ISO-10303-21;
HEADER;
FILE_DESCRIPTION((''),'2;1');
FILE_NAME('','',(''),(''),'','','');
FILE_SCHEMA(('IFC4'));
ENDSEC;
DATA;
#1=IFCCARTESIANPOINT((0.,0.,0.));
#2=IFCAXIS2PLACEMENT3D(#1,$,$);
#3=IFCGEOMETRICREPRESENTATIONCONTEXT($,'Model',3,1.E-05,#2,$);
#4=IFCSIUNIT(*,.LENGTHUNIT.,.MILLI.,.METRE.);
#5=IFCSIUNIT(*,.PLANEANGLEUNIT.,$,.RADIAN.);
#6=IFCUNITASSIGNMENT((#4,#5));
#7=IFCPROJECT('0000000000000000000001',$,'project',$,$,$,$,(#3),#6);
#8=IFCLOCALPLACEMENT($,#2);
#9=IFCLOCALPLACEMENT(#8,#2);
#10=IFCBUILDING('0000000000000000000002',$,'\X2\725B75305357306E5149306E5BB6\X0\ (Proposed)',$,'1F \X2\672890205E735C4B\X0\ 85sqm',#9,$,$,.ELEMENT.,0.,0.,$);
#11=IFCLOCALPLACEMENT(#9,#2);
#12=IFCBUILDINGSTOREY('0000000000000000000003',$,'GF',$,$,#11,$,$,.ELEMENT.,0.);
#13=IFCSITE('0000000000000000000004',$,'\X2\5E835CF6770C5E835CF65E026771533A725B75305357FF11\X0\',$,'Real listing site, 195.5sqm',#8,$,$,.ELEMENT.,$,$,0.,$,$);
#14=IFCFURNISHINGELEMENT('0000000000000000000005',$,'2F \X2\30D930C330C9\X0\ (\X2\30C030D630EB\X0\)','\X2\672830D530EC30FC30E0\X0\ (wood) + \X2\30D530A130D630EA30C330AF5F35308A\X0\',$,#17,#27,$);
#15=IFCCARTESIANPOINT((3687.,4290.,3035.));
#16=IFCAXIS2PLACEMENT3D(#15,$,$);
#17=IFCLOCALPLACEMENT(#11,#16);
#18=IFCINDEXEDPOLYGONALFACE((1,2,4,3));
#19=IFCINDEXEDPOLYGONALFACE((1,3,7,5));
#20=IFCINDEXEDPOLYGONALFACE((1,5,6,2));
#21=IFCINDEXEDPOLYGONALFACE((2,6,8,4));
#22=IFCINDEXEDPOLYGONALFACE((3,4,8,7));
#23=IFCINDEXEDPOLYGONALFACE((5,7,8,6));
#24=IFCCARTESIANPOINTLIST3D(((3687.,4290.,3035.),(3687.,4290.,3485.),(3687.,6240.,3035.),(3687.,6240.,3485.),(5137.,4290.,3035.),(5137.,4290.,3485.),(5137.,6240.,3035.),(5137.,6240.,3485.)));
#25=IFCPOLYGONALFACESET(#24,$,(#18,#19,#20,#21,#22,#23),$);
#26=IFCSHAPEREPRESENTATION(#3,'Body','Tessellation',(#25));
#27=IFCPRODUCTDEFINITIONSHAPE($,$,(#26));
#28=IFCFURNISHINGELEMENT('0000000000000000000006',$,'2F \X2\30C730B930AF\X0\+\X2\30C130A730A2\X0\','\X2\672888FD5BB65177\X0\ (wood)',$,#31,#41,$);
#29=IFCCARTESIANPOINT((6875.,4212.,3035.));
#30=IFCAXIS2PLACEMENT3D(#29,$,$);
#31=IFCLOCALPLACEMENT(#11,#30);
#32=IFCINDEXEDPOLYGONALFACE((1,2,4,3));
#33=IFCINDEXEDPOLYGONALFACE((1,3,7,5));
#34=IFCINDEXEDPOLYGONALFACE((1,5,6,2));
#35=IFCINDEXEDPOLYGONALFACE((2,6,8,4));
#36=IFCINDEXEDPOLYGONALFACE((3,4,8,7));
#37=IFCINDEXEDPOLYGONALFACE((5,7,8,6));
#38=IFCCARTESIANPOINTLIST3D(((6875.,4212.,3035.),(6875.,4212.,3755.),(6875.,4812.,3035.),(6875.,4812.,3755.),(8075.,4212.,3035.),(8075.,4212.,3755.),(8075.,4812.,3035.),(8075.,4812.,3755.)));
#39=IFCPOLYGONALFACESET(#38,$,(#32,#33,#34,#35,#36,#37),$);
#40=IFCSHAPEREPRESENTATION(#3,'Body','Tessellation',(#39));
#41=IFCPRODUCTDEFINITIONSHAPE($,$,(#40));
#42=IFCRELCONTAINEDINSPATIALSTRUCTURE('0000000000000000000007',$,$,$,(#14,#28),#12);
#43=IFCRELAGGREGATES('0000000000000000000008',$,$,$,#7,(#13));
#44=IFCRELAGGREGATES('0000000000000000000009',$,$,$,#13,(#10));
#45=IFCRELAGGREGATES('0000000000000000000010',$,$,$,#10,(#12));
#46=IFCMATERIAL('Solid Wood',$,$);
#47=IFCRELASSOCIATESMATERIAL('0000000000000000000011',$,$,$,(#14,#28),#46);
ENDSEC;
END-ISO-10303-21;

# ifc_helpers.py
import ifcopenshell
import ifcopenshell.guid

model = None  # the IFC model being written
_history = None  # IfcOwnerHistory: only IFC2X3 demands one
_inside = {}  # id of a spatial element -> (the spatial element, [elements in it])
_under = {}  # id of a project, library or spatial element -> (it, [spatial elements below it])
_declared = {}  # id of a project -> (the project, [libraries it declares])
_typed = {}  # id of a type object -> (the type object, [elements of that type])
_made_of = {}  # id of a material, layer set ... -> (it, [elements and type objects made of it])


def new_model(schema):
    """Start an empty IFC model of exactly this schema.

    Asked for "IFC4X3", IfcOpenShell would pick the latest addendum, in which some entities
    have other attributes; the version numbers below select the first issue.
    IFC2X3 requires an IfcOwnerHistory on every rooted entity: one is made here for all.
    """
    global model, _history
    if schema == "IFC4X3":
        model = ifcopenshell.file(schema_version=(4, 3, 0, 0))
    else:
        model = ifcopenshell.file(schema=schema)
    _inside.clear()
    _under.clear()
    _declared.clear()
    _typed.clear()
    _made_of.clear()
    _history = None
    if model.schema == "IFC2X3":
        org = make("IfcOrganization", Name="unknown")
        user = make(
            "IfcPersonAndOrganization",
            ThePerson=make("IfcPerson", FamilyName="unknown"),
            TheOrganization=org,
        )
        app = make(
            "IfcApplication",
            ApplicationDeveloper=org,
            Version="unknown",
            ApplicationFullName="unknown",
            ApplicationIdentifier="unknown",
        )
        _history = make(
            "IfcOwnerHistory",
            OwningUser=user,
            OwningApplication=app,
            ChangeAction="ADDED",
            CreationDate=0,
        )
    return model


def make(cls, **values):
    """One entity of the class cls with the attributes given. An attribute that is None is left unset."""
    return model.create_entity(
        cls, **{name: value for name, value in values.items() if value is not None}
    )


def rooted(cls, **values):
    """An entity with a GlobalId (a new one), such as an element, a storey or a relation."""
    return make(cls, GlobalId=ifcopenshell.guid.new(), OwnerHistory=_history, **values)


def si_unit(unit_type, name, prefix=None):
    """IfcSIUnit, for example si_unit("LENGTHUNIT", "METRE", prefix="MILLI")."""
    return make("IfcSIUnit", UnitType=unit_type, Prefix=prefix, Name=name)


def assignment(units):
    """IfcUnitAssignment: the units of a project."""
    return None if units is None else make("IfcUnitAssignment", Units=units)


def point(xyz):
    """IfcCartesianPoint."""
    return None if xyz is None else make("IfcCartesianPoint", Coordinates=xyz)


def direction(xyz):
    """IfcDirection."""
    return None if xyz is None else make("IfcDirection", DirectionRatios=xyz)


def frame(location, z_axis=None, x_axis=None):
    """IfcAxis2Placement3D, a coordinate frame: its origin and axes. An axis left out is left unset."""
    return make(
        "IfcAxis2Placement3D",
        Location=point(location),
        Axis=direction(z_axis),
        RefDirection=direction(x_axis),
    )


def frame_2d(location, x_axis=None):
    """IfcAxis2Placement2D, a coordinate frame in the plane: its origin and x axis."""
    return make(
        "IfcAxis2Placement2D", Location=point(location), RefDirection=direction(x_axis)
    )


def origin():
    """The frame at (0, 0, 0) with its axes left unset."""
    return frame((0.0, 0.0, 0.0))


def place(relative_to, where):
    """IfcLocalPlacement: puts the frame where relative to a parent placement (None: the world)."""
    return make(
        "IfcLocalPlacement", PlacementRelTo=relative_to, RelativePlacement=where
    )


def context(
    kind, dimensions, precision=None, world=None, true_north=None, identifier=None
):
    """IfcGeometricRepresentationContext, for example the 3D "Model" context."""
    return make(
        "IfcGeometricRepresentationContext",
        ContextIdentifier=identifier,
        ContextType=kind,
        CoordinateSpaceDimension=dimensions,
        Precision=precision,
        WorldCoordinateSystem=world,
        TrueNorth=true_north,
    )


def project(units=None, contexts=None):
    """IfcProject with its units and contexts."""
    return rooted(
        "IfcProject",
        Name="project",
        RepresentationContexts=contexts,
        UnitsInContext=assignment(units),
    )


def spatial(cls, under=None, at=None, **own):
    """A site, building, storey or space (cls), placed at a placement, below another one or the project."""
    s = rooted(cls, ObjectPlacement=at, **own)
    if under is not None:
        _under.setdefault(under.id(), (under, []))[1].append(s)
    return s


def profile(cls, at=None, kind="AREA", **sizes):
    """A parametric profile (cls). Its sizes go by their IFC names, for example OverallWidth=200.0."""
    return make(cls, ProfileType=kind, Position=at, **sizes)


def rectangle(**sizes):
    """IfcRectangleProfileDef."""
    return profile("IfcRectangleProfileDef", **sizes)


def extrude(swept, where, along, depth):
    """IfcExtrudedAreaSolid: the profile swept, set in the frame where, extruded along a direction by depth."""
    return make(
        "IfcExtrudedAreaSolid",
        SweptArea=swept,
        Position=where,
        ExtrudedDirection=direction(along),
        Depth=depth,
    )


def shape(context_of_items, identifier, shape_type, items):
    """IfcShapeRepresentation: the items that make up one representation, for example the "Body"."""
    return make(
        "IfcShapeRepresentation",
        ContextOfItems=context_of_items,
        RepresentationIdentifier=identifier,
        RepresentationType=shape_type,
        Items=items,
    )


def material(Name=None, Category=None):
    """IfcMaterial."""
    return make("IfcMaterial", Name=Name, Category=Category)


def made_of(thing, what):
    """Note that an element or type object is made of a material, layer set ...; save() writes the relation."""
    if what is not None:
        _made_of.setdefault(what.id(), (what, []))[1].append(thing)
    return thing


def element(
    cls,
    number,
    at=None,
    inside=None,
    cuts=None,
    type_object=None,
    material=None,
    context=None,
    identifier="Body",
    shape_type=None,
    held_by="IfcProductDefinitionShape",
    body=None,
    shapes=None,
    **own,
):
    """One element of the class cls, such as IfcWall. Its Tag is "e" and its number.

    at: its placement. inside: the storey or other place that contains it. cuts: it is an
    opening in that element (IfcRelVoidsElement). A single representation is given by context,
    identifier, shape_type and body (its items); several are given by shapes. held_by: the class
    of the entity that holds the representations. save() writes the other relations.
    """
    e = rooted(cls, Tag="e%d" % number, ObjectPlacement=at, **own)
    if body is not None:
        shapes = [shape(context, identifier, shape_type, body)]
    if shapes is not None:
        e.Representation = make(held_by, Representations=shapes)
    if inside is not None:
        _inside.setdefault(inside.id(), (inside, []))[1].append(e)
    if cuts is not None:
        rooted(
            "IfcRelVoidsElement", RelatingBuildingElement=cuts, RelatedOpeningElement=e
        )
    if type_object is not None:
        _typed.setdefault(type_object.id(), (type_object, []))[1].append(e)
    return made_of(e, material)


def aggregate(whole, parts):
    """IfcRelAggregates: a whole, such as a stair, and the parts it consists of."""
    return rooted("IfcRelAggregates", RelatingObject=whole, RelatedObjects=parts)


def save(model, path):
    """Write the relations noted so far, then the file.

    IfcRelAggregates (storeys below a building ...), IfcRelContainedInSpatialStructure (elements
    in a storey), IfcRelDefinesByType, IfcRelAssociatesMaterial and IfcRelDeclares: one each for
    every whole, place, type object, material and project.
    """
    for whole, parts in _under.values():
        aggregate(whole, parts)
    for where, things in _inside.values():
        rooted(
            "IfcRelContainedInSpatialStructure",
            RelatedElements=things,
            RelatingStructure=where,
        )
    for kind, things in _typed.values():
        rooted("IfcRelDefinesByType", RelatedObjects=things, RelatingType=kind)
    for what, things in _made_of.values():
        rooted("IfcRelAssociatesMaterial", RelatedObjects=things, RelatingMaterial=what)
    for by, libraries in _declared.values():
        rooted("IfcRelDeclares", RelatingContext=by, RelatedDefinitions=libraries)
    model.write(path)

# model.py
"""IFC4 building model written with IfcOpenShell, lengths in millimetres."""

from ifc_helpers import new_model, si_unit, frame, frame_2d, origin, place, context, project, spatial, rectangle, extrude, material, element, save


model = new_model("IFC4")

# Units and contexts
model_context = context("Model", 3, precision=1e-05, world=origin())
ifc_project = project(units=[si_unit("LENGTHUNIT", "METRE", prefix="MILLI"), si_unit("PLANEANGLEUNIT", "RADIAN")], contexts=[model_context])

# Site, building, storey
site_placement = place(None, origin())
site = spatial("IfcSite", under=ifc_project, at=site_placement, Name="広島県広島市東区牛田南１", ObjectType="Real listing site, 195.5sqm", CompositionType="ELEMENT", RefElevation=0.0)
building_placement = place(site_placement, origin())
building = spatial("IfcBuilding", under=site, at=building_placement, Name="牛田南の光の家 (Proposed)", ObjectType="1F 木造平屋 85sqm", CompositionType="ELEMENT", ElevationOfRefHeight=0.0, ElevationOfTerrain=0.0)
storey_placement = place(building_placement, origin())
storey = spatial("IfcBuildingStorey", under=building, at=storey_placement, Name="GF", CompositionType="ELEMENT", Elevation=0.0)

# Shared definitions
ifc_material_1 = material(Name="Solid Wood")

# Furnishing elements
furnishing_1_placement = place(storey_placement, frame((3687.0, 4290.0, 3035.0)))
element("IfcFurnishingElement", 1, at=furnishing_1_placement, inside=storey, material=ifc_material_1, Name="2F ベッド (ダブル)", Description="木フレーム (wood) + ファブリック張り", context=model_context, shape_type="SweptSolid", body=[
    extrude(rectangle(XDim=1450.0, YDim=1950.0, at=frame_2d((725.0, 975.0))), frame((3687.0, 4290.0, 3035.0)), (0.0, 0.0, 1.0), 450.0),
])
furnishing_2_placement = place(storey_placement, frame((6875.0, 4212.0, 3035.0)))
element("IfcFurnishingElement", 2, at=furnishing_2_placement, inside=storey, material=ifc_material_1, Name="2F デスク+チェア", Description="木製家具 (wood)", context=model_context, shape_type="SweptSolid", body=[
    extrude(rectangle(XDim=1200.0, YDim=600.0, at=frame_2d((600.0, 300.0))), frame((6875.0, 4212.0, 3035.0)), (0.0, 0.0, 1.0), 720.0),
])

save(model, "model.ifc")
